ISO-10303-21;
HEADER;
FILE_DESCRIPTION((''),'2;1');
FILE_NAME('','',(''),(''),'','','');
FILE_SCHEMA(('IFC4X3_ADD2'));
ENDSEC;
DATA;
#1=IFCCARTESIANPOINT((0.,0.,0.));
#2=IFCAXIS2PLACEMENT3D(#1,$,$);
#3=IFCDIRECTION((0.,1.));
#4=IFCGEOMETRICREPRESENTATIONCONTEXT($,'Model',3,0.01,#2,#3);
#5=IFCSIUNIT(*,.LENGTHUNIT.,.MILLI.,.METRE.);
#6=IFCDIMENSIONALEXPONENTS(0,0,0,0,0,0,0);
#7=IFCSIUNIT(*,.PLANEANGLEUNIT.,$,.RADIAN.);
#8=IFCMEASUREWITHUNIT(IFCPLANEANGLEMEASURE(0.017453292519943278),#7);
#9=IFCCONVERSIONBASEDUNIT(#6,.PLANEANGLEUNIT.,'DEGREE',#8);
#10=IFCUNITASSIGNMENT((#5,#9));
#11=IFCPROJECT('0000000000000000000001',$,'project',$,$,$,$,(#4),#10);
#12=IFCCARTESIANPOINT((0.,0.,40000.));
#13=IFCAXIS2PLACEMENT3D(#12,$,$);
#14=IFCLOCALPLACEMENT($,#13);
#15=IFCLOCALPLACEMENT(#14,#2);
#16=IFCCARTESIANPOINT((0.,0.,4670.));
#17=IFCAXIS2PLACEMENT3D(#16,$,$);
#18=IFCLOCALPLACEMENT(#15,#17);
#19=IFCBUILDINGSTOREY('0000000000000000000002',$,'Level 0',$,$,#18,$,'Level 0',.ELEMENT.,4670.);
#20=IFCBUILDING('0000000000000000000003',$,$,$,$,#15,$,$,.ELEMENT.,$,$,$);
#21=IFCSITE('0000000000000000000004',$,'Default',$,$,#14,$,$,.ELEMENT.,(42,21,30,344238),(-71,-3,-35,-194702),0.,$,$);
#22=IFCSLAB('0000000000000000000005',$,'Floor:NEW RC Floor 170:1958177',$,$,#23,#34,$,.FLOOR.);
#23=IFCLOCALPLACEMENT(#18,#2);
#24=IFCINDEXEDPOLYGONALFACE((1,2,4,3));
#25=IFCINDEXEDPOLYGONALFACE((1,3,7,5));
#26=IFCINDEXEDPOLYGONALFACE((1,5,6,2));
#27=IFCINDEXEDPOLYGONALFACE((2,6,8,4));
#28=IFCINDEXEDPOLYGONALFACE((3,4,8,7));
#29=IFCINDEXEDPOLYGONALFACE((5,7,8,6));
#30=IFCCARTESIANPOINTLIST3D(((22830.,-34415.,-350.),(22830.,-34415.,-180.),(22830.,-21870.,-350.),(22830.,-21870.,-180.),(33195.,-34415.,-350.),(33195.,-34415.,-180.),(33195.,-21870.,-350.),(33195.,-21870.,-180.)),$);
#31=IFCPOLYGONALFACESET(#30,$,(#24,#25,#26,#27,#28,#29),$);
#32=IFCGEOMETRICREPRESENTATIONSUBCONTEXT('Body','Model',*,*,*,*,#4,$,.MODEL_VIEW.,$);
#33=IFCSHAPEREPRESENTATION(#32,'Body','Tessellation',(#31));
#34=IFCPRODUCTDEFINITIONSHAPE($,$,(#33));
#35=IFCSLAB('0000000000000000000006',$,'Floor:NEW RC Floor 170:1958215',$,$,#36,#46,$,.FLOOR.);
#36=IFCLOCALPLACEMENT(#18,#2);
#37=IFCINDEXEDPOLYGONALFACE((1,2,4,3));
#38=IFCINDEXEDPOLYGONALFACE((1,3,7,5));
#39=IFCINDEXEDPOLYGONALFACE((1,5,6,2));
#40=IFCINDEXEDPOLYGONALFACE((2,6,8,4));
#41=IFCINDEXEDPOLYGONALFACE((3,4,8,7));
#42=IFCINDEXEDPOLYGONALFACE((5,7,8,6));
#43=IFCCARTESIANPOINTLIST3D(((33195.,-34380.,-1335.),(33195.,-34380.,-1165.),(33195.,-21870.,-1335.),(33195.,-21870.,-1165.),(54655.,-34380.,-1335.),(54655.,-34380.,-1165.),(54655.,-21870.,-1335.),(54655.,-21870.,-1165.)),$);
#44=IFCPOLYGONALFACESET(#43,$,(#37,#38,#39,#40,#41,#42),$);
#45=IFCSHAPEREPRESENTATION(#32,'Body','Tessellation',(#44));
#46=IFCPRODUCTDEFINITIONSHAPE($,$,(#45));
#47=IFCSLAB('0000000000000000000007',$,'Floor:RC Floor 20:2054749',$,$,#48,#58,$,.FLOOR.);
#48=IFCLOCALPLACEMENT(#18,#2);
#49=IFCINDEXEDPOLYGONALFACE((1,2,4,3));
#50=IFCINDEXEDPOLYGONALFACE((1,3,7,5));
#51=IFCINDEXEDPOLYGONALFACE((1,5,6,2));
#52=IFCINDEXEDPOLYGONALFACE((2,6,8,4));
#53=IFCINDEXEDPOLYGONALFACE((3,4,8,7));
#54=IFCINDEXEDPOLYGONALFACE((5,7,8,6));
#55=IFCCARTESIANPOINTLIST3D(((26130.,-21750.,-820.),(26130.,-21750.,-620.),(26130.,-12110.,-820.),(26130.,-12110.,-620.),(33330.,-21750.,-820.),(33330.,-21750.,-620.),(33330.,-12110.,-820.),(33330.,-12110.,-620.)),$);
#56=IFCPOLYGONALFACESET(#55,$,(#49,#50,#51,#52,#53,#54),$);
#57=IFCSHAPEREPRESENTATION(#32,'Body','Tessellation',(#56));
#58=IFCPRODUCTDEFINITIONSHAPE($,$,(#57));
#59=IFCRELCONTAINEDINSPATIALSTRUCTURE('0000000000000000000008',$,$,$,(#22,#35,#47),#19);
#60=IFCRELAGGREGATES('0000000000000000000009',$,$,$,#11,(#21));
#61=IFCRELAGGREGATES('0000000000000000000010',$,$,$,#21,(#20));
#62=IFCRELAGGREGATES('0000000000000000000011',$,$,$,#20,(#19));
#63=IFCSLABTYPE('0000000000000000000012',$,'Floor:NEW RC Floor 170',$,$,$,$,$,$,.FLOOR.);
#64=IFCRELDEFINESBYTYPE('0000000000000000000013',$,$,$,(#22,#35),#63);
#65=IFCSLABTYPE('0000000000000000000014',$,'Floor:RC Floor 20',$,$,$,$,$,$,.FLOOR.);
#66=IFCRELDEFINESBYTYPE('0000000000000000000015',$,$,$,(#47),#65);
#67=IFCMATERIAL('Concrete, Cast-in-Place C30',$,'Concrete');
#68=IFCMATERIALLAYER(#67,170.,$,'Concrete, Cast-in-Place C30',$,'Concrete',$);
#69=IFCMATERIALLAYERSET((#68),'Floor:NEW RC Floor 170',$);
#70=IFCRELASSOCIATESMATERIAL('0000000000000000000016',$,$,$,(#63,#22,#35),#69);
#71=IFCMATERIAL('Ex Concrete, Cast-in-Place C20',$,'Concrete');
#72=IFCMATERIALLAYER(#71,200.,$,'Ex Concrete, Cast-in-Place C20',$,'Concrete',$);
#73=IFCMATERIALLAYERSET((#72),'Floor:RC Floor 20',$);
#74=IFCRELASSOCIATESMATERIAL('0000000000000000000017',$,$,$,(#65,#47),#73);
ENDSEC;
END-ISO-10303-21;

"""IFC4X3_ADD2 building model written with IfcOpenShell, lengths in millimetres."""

from ifc_helpers import new_model, entity, si_unit, converted_unit, direction, frame, frame_2d, origin, place, context, subcontext, project, spatial, rectangle, extrude, material, layer, layer_set, layer_usage, type_object, element, save


model = new_model("IFC4X3_ADD2")

# Units and contexts
model_context = context("Model", 3, precision=0.01, world=origin(), true_north=direction((0.0, 1.0)))
body_context = subcontext(model_context, "Body", "Model", "MODEL_VIEW")
ifc_project = project(units=[si_unit("LENGTHUNIT", "METRE", prefix="MILLI"), converted_unit("PLANEANGLEUNIT", "DEGREE", entity("IfcPlaneAngleMeasure", 0.017453292519943278), si_unit("PLANEANGLEUNIT", "RADIAN"), dimensions=[0, 0, 0, 0, 0, 0, 0])], contexts=[model_context])

# Site, building, storey
site_placement = place(None, frame((0.0, 0.0, 40000.0)))
site = spatial("IfcSite", under=ifc_project, at=site_placement, Name="Default", CompositionType="ELEMENT", RefLatitude=(42, 21, 30, 344238), RefLongitude=(-71, -3, -35, -194702), RefElevation=0.0)
building_placement = place(site_placement, origin())
building = spatial("IfcBuilding", under=site, at=building_placement, CompositionType="ELEMENT")
storey_placement = place(building_placement, frame((0.0, 0.0, 4670.0)))
storey = spatial("IfcBuildingStorey", under=building, at=storey_placement, Name="Level 0", LongName="Level 0", CompositionType="ELEMENT", Elevation=4670.0)

# Slabs
ifc_material_1 = material(Name="Ex Concrete, Cast-in-Place C20", Category="Concrete")
ifc_material_2 = material(Name="Concrete, Cast-in-Place C30", Category="Concrete")
ifc_layer_1 = layer(ifc_material_2, 170.0, Name="Concrete, Cast-in-Place C30", Category="Concrete")
ifc_layer_set_1 = layer_set([ifc_layer_1], Name="Floor:NEW RC Floor 170")
slab_type_1 = type_object("IfcSlabType", Name="Floor:NEW RC Floor 170", PredefinedType="FLOOR", material=ifc_layer_set_1)
ifc_layer_usage_1 = layer_usage(ifc_layer_set_1, "AXIS3", "POSITIVE", 0.0)
slab_1_placement = place(storey_placement, origin())
element("IfcSlab", 1, at=slab_1_placement, inside=storey, type_object=slab_type_1, material=ifc_layer_usage_1, Name="Floor:NEW RC Floor 170:1958177", PredefinedType="FLOOR", context=body_context, shape_type="SweptSolid", body=[
    extrude(rectangle(XDim=12545.0, YDim=10365.0, at=frame_2d((0.0, 0.0), x_axis=(1.0, 0.0))), frame((28012.5, -28142.5, -180.0), z_axis=(0.0, 0.0, -1.0), x_axis=(0.0, 1.0, 0.0)), (0.0, 0.0, 1.0), 170.0),
])
ifc_layer_usage_2 = layer_usage(ifc_layer_set_1, "AXIS3", "POSITIVE", 0.0)
slab_2_placement = place(storey_placement, origin())
element("IfcSlab", 2, at=slab_2_placement, inside=storey, type_object=slab_type_1, material=ifc_layer_usage_2, Name="Floor:NEW RC Floor 170:1958215", PredefinedType="FLOOR", context=body_context, shape_type="SweptSolid", body=[
    extrude(rectangle(XDim=12510.0, YDim=21460.0, at=frame_2d((0.0, 0.0), x_axis=(1.0, 0.0))), frame((43925.0, -28125.0, -1165.0), z_axis=(0.0, 0.0, -1.0), x_axis=(0.0, 1.0, 0.0)), (0.0, 0.0, 1.0), 170.0),
])
ifc_layer_2 = layer(ifc_material_1, 200.0, Name="Ex Concrete, Cast-in-Place C20", Category="Concrete")
ifc_layer_set_2 = layer_set([ifc_layer_2], Name="Floor:RC Floor 20")
ifc_layer_usage_3 = layer_usage(ifc_layer_set_2, "AXIS3", "POSITIVE", 0.0)
slab_type_2 = type_object("IfcSlabType", Name="Floor:RC Floor 20", PredefinedType="FLOOR", material=ifc_layer_set_2)
slab_3_placement = place(storey_placement, origin())
element("IfcSlab", 3, at=slab_3_placement, inside=storey, type_object=slab_type_2, material=ifc_layer_usage_3, Name="Floor:RC Floor 20:2054749", PredefinedType="FLOOR", context=body_context, shape_type="SweptSolid", body=[
    extrude(rectangle(XDim=9640.0, YDim=7200.0, at=frame_2d((0.0, 0.0), x_axis=(1.0, 0.0))), frame((29730.0, -16930.0, -620.0), z_axis=(0.0, 0.0, -1.0), x_axis=(0.0, 1.0, 0.0)), (0.0, 0.0, 1.0), 200.0),
])

save(model, "model.ifc")
